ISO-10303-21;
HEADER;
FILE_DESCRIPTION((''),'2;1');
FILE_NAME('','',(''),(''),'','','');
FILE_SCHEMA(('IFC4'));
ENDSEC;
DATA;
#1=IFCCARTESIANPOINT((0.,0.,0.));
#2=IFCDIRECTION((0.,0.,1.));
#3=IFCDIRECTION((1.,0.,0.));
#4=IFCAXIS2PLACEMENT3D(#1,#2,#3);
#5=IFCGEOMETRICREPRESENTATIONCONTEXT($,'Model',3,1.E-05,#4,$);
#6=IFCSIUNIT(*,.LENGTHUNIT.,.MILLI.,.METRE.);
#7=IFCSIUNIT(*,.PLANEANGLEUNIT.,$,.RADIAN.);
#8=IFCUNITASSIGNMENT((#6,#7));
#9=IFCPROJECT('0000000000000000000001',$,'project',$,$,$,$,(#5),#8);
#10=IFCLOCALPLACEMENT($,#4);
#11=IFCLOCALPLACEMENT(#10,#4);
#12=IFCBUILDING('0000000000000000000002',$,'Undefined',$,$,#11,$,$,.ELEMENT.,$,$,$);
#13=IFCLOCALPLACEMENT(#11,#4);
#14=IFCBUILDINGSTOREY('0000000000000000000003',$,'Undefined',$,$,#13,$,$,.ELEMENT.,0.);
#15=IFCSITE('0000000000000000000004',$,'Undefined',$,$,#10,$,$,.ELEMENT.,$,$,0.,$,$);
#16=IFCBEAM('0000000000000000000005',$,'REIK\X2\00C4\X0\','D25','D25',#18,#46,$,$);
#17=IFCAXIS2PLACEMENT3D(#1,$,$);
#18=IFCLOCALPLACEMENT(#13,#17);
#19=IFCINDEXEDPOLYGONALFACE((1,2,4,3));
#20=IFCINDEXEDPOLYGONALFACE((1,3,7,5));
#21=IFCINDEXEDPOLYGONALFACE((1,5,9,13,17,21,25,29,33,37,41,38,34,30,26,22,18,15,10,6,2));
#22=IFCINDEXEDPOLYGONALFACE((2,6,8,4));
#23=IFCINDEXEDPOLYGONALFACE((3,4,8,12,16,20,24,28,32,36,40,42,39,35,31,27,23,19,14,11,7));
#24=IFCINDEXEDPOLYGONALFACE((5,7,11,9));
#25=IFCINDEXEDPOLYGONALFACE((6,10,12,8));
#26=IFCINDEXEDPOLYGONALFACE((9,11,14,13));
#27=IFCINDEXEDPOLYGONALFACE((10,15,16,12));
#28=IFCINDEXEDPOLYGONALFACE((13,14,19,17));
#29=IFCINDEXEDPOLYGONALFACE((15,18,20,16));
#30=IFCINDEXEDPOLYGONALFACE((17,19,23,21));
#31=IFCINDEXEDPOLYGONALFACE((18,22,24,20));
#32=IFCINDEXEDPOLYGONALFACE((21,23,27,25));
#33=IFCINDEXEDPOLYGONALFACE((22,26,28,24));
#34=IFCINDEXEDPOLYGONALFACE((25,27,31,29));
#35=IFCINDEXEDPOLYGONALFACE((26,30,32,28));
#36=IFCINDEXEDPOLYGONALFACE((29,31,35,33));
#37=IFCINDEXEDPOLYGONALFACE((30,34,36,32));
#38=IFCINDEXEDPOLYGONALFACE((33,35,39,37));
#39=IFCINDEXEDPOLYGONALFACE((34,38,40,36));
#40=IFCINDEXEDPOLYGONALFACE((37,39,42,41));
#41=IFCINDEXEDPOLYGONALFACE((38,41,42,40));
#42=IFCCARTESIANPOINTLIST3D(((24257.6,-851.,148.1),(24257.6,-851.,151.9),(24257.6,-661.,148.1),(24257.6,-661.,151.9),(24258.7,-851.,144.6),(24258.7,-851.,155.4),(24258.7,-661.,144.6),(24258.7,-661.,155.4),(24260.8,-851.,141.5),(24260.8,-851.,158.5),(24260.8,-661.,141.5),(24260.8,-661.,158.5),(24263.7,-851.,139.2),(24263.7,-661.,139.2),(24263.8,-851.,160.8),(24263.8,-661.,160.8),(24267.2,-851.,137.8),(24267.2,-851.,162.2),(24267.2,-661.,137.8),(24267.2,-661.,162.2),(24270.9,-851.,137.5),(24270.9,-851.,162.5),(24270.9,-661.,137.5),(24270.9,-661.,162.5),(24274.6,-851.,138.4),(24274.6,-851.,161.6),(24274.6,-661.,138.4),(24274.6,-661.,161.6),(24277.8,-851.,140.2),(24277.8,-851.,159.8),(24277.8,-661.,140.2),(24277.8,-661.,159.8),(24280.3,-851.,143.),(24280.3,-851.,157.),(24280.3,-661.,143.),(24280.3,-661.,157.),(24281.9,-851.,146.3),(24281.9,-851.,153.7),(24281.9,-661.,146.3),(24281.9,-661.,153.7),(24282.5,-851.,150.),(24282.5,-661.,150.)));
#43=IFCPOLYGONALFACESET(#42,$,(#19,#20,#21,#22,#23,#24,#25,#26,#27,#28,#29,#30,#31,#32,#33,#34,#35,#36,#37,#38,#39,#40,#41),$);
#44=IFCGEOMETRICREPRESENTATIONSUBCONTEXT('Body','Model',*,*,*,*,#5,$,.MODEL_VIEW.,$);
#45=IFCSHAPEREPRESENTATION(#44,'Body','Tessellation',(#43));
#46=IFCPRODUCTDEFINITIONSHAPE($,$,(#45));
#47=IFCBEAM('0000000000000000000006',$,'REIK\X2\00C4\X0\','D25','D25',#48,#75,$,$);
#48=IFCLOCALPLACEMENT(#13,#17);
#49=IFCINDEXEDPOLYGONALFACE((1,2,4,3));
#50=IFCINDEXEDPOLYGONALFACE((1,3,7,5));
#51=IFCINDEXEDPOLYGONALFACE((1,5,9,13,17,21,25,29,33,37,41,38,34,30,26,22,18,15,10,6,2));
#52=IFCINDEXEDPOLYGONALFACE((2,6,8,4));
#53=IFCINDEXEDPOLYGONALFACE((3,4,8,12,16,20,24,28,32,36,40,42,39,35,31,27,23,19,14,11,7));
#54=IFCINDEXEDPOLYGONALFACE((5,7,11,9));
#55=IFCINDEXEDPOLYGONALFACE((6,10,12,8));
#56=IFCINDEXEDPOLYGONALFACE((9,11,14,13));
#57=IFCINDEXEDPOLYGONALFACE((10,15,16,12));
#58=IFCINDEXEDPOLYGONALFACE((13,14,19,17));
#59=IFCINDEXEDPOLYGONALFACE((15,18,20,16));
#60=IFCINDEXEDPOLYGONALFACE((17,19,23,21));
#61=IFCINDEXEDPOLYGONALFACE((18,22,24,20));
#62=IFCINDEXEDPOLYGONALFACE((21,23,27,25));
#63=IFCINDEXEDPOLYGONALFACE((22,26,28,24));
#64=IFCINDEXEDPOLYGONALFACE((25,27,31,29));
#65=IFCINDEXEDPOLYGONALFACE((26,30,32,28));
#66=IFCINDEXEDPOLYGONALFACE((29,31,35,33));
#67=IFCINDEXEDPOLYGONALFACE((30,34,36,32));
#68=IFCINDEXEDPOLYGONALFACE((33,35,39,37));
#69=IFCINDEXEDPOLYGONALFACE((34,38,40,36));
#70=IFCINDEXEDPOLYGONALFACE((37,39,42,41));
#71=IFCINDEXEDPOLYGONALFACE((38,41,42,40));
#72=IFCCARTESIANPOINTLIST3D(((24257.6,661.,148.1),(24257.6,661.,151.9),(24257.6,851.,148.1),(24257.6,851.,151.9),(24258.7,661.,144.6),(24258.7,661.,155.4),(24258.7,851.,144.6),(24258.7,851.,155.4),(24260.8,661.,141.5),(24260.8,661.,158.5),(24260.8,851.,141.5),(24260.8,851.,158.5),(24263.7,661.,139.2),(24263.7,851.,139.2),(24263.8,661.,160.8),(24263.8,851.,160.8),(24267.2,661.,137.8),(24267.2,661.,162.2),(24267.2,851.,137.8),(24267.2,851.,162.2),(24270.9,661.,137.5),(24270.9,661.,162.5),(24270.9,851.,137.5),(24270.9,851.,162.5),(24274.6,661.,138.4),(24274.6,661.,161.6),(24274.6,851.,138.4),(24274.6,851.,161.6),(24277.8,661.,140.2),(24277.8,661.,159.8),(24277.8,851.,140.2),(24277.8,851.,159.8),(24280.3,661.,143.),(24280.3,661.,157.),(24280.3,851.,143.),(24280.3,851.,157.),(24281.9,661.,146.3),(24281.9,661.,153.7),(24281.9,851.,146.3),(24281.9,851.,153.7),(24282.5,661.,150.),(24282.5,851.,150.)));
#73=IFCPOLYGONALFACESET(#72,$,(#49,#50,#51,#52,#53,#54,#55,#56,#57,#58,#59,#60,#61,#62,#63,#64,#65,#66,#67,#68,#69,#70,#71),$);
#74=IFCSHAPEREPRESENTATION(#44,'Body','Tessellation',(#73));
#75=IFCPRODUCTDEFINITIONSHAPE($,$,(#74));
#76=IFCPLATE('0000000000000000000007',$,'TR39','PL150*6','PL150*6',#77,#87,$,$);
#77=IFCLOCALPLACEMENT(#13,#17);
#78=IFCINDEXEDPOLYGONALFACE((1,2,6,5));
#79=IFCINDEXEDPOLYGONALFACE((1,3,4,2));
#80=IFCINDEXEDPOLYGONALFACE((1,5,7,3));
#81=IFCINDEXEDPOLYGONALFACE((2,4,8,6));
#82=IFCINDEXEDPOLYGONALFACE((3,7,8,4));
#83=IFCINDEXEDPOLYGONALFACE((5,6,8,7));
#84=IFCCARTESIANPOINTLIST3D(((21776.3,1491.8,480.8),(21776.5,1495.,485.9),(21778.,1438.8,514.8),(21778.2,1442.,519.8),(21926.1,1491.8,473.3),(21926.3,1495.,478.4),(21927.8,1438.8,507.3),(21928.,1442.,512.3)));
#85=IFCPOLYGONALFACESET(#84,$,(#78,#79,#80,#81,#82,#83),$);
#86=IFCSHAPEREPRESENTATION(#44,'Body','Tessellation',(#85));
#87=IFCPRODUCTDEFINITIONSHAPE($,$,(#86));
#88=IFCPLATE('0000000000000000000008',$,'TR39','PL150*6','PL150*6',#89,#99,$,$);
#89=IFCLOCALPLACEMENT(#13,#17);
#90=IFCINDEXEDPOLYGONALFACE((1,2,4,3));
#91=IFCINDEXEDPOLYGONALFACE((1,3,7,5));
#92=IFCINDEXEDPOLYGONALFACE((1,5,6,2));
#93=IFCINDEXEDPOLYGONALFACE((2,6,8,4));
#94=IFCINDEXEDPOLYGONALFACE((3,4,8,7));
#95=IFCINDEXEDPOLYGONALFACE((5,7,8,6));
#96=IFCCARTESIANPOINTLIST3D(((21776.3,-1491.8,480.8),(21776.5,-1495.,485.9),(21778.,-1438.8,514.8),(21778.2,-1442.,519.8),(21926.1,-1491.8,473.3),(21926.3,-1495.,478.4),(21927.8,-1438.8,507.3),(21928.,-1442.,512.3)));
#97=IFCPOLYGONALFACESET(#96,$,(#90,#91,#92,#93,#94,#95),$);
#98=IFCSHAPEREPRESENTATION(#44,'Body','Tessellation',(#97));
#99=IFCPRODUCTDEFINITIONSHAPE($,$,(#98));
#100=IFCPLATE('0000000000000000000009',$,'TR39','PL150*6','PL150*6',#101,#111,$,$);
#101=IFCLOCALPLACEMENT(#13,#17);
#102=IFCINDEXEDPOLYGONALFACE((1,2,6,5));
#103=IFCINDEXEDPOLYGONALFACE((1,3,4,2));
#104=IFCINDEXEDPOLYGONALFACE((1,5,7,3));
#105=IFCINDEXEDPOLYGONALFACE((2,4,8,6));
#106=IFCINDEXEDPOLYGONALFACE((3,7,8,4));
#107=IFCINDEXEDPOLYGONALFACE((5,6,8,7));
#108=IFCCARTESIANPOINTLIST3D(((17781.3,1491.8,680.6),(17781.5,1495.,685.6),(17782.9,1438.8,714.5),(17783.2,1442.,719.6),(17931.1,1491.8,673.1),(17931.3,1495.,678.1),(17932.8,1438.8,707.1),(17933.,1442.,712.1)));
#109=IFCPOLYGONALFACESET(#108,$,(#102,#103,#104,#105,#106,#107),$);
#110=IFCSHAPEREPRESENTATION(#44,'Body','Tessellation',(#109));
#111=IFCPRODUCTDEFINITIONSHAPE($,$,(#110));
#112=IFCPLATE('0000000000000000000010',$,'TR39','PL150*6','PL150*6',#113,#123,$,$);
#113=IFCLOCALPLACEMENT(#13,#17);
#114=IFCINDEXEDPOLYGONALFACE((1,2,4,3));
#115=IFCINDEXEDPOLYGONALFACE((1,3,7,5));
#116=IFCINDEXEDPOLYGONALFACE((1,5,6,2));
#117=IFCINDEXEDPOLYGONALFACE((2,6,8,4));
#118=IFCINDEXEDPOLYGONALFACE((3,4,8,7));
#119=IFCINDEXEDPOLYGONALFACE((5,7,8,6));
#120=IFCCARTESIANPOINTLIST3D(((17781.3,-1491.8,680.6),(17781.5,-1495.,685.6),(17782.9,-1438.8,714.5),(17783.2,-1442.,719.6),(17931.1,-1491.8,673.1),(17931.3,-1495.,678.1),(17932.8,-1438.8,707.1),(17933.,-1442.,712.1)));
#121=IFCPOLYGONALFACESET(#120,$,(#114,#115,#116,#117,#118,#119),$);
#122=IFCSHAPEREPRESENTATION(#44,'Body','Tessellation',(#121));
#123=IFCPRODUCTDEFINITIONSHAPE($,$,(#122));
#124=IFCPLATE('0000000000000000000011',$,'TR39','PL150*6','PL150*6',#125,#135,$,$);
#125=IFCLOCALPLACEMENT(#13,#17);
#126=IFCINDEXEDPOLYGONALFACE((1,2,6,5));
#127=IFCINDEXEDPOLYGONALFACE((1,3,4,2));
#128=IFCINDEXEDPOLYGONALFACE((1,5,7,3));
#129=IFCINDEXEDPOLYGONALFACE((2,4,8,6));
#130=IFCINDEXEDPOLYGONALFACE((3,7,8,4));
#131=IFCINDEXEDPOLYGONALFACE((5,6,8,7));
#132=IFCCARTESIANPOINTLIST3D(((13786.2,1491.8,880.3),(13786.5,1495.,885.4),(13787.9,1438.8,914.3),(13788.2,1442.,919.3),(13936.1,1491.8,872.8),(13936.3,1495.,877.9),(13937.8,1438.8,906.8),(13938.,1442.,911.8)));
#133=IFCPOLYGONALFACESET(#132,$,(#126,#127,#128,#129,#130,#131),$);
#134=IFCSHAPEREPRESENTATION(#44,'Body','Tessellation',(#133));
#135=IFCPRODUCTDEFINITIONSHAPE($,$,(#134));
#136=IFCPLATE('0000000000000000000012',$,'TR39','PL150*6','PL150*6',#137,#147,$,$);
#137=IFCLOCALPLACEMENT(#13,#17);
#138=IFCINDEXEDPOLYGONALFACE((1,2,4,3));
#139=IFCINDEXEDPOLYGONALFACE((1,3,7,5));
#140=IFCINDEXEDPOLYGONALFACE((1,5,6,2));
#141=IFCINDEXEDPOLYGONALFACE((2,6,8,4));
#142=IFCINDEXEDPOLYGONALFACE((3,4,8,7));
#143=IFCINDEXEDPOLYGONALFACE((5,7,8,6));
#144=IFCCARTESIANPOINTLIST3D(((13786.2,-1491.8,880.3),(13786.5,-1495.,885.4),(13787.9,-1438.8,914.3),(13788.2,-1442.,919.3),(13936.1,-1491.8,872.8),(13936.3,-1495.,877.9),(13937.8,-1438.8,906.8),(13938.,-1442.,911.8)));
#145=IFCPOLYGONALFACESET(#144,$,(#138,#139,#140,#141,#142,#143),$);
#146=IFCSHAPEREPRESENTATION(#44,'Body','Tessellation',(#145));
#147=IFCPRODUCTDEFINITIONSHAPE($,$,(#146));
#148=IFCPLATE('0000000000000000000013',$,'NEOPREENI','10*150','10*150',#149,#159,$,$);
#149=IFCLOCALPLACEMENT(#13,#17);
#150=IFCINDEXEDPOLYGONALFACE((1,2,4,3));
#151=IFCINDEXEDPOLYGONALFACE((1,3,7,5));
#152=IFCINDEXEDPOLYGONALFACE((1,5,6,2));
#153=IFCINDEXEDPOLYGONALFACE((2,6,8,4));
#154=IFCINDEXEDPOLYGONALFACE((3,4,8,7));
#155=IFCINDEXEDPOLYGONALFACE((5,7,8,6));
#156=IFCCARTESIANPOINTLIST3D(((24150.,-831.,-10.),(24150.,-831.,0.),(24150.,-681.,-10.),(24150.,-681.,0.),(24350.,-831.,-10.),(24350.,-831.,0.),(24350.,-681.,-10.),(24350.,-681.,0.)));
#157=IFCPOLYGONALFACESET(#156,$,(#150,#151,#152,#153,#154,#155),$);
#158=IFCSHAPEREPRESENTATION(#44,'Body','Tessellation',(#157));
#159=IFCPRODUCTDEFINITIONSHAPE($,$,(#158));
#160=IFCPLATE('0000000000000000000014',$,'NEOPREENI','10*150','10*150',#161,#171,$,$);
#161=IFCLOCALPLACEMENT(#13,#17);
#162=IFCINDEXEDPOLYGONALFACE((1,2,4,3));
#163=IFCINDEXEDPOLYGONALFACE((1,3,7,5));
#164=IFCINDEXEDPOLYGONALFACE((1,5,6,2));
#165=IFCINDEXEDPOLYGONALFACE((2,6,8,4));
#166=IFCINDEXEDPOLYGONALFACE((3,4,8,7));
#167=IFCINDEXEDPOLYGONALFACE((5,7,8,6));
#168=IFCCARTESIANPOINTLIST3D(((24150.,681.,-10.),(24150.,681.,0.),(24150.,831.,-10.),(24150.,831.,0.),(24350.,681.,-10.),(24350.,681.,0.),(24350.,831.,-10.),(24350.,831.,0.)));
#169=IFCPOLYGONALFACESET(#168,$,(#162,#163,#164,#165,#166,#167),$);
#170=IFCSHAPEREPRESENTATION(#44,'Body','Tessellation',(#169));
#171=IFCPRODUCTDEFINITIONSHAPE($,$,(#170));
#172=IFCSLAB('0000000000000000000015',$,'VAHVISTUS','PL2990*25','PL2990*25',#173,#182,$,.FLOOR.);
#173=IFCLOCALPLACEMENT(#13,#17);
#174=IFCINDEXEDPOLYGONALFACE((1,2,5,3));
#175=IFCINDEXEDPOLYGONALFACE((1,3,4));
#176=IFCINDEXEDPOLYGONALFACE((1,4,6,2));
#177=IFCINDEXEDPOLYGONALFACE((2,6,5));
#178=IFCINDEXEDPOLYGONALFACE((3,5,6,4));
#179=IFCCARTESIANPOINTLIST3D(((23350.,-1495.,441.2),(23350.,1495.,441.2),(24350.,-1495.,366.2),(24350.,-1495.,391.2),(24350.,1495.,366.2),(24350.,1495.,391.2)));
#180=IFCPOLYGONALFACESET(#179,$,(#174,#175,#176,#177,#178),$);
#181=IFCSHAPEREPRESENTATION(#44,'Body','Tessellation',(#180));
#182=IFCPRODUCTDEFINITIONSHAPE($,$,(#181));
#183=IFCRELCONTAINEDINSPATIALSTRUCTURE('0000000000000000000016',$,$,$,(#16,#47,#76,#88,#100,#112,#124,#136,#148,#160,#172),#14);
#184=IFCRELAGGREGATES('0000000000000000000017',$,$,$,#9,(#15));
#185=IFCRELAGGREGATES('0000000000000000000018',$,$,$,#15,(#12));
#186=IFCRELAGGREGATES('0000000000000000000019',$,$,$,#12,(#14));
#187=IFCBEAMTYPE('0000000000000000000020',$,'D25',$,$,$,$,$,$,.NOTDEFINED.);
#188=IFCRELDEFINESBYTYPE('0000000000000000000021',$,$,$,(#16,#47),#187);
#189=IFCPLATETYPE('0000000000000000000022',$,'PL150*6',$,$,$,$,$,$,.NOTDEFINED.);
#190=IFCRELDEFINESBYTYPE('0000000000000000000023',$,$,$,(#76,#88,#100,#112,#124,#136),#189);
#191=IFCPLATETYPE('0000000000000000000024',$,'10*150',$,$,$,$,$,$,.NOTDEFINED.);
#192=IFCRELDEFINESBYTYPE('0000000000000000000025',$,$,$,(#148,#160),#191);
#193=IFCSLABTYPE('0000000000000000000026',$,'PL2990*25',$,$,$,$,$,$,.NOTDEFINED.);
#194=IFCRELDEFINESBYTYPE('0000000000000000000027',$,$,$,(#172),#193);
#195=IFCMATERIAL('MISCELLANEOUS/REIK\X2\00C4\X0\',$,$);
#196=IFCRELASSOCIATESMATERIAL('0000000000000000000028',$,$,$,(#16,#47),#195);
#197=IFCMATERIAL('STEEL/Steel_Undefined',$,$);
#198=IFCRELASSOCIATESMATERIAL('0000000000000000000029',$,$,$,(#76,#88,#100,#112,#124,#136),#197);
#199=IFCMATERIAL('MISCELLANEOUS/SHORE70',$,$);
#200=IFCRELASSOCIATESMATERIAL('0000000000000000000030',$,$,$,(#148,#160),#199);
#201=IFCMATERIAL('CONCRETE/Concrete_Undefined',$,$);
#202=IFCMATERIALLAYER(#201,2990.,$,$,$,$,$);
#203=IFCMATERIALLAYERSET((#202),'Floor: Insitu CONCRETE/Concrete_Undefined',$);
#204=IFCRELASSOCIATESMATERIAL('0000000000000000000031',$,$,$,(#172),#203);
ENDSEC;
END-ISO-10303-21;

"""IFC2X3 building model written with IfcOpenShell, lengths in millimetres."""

from ifc_helpers import new_model, si_unit, frame, origin_with_axes, origin_2d_with_axis, place, context, subcontext, project, spatial, polyline, circle, outline, extrude, material, layer, layer_set, layer_usage, type_object, element, save


model = new_model("IFC2X3")

# Units and contexts
model_context = context("Model", 3, precision=1e-05, world=origin_with_axes())
body_context = subcontext(model_context, "Body", "Model", "MODEL_VIEW")
ifc_project = project(units=[si_unit("LENGTHUNIT", "METRE", prefix="MILLI"), si_unit("PLANEANGLEUNIT", "RADIAN")], contexts=[model_context])

# Site, building, storey
site_placement = place(None, origin_with_axes())
site = spatial("IfcSite", under=ifc_project, at=site_placement, Name="Undefined", CompositionType="ELEMENT", RefElevation=0.0)
building_placement = place(site_placement, origin_with_axes())
building = spatial("IfcBuilding", under=site, at=building_placement, Name="Undefined", CompositionType="ELEMENT")
storey_placement = place(building_placement, origin_with_axes())
storey = spatial("IfcBuildingStorey", under=building, at=storey_placement, Name="Undefined", CompositionType="ELEMENT", Elevation=0.0)

# Beams
ifc_material_1 = material(Name="MISCELLANEOUS/REIKÄ")
beam_type = type_object("IfcBeamType", Name="D25", PredefinedType="NOTDEFINED")
for number, where, z_axis, x_axis, name in (
    (1, (24270.0, -851.0, 150.0), (0.0, 0.0, 1.0), (0.0, 1.0, 0.0), "REIKÄ"),
    (2, (24270.0, 661.0, 150.0), (0.0, 0.0, 1.0), (0.0, 1.0, 0.0), "REIKÄ"),
):
    element("IfcBeam", number, at=place(storey_placement, frame(where, z_axis=z_axis, x_axis=x_axis)), inside=storey, type_object=beam_type, material=ifc_material_1, Name=name, Description="D25", ObjectType="D25", context=body_context, shape_type="SweptSolid", body=[
        extrude(circle(Radius=12.5, at=origin_2d_with_axis()), frame((190.0, 0.0, 0.0), z_axis=(-1.0, 0.0, 0.0), x_axis=(0.0, -1.0, 0.0)), (0.0, 0.0, 1.0), 190.0),
    ])

# Plates
ifc_material_2 = material(Name="STEEL/Steel_Undefined")
plate_type_1 = type_object("IfcPlateType", Name="PL150*6", PredefinedType="NOTDEFINED")
for number, where, z_axis, x_axis, name in (
    (3, (21853.1, 1442.0, 516.1), (-0.998752, 0.0, 0.049938), (-0.026964, 0.841694, -0.539281), "TR39"),
    (4, (21853.1, -1442.0, 516.1), (0.998752, 0.0, -0.049938), (-0.026964, -0.841694, -0.539281), "TR39"),
    (5, (17858.1, 1442.0, 715.8), (-0.998752, 0.0, 0.049938), (-0.026964, 0.841694, -0.539281), "TR39"),
    (6, (17858.1, -1442.0, 715.8), (0.998752, 0.0, -0.049938), (-0.026964, -0.841694, -0.539281), "TR39"),
    (7, (13863.1, 1442.0, 915.6), (-0.998752, 0.0, 0.049938), (-0.026964, 0.841694, -0.539281), "TR39"),
    (8, (13863.1, -1442.0, 915.6), (0.998752, 0.0, -0.049938), (-0.026964, -0.841694, -0.539281), "TR39"),
):
    element("IfcPlate", number, at=place(storey_placement, frame(where, z_axis=z_axis, x_axis=x_axis)), inside=storey, type_object=plate_type_1, material=ifc_material_2, Name=name, Description="PL150*6", ObjectType="PL150*6", context=body_context, shape_type="SweptSolid", body=[
        extrude(outline(polyline([(0.0, 0.0), (63.0, 0.0), (63.0, 6.0), (0.0, 6.0), (0.0, 0.0)])), frame((0.0, 0.0, -75.0), z_axis=(0.0, 0.0, 1.0), x_axis=(1.0, 0.0, 0.0)), (0.0, 0.0, 1.0), 150.0),
    ])
ifc_material_3 = material(Name="MISCELLANEOUS/SHORE70")
plate_type_2 = type_object("IfcPlateType", Name="10*150", PredefinedType="NOTDEFINED")
for number, where, z_axis, x_axis, name in (
    (9, (24150.0, -831.0, -5.0), (0.0, 0.0, 1.0), (1.0, 0.0, 0.0), "NEOPREENI"),
    (10, (24150.0, 681.0, -5.0), (0.0, 0.0, 1.0), (1.0, 0.0, 0.0), "NEOPREENI"),
):
    element("IfcPlate", number, at=place(storey_placement, frame(where, z_axis=z_axis, x_axis=x_axis)), inside=storey, type_object=plate_type_2, material=ifc_material_3, Name=name, Description="10*150", ObjectType="10*150", context=body_context, shape_type="SweptSolid", body=[
        extrude(outline(polyline([(0.0, 0.0), (200.0, 0.0), (200.0, 150.0), (0.0, 150.0), (0.0, 0.0)])), frame((0.0, 0.0, -5.0), z_axis=(0.0, 0.0, 1.0), x_axis=(1.0, 0.0, 0.0)), (0.0, 0.0, 1.0), 10.0),
    ])

# Slab
ifc_material_4 = material(Name="CONCRETE/Concrete_Undefined")
ifc_layer = layer(ifc_material_4, 2990.0)
ifc_layer_set = layer_set([ifc_layer], Name="Floor: Insitu CONCRETE/Concrete_Undefined")
ifc_layer_usage = layer_usage(ifc_layer_set, "AXIS3", "POSITIVE", -1495.0)
slab_type = type_object("IfcSlabType", Name="PL2990*25", PredefinedType="NOTDEFINED")
slab_placement = place(storey_placement, frame((24350.0, 0.0, 391.2), z_axis=(0.0, 1.0, 0.0), x_axis=(0.0, 0.0, -1.0)))
element("IfcSlab", 11, at=slab_placement, inside=storey, type_object=slab_type, material=ifc_layer_usage, Name="VAHVISTUS", Description="PL2990*25", ObjectType="PL2990*25", PredefinedType="FLOOR", context=body_context, shape_type="SweptSolid", body=[
    extrude(outline(polyline([(0.0, 0.0), (25.0, 0.0), (-50.0, 1000.0), (0.0, 0.0)])), frame((0.0, 0.0, -1495.0), z_axis=(0.0, 0.0, 1.0), x_axis=(1.0, 0.0, 0.0)), (0.0, 0.0, 1.0), 2990.0),
])

save(model, "model.ifc")
